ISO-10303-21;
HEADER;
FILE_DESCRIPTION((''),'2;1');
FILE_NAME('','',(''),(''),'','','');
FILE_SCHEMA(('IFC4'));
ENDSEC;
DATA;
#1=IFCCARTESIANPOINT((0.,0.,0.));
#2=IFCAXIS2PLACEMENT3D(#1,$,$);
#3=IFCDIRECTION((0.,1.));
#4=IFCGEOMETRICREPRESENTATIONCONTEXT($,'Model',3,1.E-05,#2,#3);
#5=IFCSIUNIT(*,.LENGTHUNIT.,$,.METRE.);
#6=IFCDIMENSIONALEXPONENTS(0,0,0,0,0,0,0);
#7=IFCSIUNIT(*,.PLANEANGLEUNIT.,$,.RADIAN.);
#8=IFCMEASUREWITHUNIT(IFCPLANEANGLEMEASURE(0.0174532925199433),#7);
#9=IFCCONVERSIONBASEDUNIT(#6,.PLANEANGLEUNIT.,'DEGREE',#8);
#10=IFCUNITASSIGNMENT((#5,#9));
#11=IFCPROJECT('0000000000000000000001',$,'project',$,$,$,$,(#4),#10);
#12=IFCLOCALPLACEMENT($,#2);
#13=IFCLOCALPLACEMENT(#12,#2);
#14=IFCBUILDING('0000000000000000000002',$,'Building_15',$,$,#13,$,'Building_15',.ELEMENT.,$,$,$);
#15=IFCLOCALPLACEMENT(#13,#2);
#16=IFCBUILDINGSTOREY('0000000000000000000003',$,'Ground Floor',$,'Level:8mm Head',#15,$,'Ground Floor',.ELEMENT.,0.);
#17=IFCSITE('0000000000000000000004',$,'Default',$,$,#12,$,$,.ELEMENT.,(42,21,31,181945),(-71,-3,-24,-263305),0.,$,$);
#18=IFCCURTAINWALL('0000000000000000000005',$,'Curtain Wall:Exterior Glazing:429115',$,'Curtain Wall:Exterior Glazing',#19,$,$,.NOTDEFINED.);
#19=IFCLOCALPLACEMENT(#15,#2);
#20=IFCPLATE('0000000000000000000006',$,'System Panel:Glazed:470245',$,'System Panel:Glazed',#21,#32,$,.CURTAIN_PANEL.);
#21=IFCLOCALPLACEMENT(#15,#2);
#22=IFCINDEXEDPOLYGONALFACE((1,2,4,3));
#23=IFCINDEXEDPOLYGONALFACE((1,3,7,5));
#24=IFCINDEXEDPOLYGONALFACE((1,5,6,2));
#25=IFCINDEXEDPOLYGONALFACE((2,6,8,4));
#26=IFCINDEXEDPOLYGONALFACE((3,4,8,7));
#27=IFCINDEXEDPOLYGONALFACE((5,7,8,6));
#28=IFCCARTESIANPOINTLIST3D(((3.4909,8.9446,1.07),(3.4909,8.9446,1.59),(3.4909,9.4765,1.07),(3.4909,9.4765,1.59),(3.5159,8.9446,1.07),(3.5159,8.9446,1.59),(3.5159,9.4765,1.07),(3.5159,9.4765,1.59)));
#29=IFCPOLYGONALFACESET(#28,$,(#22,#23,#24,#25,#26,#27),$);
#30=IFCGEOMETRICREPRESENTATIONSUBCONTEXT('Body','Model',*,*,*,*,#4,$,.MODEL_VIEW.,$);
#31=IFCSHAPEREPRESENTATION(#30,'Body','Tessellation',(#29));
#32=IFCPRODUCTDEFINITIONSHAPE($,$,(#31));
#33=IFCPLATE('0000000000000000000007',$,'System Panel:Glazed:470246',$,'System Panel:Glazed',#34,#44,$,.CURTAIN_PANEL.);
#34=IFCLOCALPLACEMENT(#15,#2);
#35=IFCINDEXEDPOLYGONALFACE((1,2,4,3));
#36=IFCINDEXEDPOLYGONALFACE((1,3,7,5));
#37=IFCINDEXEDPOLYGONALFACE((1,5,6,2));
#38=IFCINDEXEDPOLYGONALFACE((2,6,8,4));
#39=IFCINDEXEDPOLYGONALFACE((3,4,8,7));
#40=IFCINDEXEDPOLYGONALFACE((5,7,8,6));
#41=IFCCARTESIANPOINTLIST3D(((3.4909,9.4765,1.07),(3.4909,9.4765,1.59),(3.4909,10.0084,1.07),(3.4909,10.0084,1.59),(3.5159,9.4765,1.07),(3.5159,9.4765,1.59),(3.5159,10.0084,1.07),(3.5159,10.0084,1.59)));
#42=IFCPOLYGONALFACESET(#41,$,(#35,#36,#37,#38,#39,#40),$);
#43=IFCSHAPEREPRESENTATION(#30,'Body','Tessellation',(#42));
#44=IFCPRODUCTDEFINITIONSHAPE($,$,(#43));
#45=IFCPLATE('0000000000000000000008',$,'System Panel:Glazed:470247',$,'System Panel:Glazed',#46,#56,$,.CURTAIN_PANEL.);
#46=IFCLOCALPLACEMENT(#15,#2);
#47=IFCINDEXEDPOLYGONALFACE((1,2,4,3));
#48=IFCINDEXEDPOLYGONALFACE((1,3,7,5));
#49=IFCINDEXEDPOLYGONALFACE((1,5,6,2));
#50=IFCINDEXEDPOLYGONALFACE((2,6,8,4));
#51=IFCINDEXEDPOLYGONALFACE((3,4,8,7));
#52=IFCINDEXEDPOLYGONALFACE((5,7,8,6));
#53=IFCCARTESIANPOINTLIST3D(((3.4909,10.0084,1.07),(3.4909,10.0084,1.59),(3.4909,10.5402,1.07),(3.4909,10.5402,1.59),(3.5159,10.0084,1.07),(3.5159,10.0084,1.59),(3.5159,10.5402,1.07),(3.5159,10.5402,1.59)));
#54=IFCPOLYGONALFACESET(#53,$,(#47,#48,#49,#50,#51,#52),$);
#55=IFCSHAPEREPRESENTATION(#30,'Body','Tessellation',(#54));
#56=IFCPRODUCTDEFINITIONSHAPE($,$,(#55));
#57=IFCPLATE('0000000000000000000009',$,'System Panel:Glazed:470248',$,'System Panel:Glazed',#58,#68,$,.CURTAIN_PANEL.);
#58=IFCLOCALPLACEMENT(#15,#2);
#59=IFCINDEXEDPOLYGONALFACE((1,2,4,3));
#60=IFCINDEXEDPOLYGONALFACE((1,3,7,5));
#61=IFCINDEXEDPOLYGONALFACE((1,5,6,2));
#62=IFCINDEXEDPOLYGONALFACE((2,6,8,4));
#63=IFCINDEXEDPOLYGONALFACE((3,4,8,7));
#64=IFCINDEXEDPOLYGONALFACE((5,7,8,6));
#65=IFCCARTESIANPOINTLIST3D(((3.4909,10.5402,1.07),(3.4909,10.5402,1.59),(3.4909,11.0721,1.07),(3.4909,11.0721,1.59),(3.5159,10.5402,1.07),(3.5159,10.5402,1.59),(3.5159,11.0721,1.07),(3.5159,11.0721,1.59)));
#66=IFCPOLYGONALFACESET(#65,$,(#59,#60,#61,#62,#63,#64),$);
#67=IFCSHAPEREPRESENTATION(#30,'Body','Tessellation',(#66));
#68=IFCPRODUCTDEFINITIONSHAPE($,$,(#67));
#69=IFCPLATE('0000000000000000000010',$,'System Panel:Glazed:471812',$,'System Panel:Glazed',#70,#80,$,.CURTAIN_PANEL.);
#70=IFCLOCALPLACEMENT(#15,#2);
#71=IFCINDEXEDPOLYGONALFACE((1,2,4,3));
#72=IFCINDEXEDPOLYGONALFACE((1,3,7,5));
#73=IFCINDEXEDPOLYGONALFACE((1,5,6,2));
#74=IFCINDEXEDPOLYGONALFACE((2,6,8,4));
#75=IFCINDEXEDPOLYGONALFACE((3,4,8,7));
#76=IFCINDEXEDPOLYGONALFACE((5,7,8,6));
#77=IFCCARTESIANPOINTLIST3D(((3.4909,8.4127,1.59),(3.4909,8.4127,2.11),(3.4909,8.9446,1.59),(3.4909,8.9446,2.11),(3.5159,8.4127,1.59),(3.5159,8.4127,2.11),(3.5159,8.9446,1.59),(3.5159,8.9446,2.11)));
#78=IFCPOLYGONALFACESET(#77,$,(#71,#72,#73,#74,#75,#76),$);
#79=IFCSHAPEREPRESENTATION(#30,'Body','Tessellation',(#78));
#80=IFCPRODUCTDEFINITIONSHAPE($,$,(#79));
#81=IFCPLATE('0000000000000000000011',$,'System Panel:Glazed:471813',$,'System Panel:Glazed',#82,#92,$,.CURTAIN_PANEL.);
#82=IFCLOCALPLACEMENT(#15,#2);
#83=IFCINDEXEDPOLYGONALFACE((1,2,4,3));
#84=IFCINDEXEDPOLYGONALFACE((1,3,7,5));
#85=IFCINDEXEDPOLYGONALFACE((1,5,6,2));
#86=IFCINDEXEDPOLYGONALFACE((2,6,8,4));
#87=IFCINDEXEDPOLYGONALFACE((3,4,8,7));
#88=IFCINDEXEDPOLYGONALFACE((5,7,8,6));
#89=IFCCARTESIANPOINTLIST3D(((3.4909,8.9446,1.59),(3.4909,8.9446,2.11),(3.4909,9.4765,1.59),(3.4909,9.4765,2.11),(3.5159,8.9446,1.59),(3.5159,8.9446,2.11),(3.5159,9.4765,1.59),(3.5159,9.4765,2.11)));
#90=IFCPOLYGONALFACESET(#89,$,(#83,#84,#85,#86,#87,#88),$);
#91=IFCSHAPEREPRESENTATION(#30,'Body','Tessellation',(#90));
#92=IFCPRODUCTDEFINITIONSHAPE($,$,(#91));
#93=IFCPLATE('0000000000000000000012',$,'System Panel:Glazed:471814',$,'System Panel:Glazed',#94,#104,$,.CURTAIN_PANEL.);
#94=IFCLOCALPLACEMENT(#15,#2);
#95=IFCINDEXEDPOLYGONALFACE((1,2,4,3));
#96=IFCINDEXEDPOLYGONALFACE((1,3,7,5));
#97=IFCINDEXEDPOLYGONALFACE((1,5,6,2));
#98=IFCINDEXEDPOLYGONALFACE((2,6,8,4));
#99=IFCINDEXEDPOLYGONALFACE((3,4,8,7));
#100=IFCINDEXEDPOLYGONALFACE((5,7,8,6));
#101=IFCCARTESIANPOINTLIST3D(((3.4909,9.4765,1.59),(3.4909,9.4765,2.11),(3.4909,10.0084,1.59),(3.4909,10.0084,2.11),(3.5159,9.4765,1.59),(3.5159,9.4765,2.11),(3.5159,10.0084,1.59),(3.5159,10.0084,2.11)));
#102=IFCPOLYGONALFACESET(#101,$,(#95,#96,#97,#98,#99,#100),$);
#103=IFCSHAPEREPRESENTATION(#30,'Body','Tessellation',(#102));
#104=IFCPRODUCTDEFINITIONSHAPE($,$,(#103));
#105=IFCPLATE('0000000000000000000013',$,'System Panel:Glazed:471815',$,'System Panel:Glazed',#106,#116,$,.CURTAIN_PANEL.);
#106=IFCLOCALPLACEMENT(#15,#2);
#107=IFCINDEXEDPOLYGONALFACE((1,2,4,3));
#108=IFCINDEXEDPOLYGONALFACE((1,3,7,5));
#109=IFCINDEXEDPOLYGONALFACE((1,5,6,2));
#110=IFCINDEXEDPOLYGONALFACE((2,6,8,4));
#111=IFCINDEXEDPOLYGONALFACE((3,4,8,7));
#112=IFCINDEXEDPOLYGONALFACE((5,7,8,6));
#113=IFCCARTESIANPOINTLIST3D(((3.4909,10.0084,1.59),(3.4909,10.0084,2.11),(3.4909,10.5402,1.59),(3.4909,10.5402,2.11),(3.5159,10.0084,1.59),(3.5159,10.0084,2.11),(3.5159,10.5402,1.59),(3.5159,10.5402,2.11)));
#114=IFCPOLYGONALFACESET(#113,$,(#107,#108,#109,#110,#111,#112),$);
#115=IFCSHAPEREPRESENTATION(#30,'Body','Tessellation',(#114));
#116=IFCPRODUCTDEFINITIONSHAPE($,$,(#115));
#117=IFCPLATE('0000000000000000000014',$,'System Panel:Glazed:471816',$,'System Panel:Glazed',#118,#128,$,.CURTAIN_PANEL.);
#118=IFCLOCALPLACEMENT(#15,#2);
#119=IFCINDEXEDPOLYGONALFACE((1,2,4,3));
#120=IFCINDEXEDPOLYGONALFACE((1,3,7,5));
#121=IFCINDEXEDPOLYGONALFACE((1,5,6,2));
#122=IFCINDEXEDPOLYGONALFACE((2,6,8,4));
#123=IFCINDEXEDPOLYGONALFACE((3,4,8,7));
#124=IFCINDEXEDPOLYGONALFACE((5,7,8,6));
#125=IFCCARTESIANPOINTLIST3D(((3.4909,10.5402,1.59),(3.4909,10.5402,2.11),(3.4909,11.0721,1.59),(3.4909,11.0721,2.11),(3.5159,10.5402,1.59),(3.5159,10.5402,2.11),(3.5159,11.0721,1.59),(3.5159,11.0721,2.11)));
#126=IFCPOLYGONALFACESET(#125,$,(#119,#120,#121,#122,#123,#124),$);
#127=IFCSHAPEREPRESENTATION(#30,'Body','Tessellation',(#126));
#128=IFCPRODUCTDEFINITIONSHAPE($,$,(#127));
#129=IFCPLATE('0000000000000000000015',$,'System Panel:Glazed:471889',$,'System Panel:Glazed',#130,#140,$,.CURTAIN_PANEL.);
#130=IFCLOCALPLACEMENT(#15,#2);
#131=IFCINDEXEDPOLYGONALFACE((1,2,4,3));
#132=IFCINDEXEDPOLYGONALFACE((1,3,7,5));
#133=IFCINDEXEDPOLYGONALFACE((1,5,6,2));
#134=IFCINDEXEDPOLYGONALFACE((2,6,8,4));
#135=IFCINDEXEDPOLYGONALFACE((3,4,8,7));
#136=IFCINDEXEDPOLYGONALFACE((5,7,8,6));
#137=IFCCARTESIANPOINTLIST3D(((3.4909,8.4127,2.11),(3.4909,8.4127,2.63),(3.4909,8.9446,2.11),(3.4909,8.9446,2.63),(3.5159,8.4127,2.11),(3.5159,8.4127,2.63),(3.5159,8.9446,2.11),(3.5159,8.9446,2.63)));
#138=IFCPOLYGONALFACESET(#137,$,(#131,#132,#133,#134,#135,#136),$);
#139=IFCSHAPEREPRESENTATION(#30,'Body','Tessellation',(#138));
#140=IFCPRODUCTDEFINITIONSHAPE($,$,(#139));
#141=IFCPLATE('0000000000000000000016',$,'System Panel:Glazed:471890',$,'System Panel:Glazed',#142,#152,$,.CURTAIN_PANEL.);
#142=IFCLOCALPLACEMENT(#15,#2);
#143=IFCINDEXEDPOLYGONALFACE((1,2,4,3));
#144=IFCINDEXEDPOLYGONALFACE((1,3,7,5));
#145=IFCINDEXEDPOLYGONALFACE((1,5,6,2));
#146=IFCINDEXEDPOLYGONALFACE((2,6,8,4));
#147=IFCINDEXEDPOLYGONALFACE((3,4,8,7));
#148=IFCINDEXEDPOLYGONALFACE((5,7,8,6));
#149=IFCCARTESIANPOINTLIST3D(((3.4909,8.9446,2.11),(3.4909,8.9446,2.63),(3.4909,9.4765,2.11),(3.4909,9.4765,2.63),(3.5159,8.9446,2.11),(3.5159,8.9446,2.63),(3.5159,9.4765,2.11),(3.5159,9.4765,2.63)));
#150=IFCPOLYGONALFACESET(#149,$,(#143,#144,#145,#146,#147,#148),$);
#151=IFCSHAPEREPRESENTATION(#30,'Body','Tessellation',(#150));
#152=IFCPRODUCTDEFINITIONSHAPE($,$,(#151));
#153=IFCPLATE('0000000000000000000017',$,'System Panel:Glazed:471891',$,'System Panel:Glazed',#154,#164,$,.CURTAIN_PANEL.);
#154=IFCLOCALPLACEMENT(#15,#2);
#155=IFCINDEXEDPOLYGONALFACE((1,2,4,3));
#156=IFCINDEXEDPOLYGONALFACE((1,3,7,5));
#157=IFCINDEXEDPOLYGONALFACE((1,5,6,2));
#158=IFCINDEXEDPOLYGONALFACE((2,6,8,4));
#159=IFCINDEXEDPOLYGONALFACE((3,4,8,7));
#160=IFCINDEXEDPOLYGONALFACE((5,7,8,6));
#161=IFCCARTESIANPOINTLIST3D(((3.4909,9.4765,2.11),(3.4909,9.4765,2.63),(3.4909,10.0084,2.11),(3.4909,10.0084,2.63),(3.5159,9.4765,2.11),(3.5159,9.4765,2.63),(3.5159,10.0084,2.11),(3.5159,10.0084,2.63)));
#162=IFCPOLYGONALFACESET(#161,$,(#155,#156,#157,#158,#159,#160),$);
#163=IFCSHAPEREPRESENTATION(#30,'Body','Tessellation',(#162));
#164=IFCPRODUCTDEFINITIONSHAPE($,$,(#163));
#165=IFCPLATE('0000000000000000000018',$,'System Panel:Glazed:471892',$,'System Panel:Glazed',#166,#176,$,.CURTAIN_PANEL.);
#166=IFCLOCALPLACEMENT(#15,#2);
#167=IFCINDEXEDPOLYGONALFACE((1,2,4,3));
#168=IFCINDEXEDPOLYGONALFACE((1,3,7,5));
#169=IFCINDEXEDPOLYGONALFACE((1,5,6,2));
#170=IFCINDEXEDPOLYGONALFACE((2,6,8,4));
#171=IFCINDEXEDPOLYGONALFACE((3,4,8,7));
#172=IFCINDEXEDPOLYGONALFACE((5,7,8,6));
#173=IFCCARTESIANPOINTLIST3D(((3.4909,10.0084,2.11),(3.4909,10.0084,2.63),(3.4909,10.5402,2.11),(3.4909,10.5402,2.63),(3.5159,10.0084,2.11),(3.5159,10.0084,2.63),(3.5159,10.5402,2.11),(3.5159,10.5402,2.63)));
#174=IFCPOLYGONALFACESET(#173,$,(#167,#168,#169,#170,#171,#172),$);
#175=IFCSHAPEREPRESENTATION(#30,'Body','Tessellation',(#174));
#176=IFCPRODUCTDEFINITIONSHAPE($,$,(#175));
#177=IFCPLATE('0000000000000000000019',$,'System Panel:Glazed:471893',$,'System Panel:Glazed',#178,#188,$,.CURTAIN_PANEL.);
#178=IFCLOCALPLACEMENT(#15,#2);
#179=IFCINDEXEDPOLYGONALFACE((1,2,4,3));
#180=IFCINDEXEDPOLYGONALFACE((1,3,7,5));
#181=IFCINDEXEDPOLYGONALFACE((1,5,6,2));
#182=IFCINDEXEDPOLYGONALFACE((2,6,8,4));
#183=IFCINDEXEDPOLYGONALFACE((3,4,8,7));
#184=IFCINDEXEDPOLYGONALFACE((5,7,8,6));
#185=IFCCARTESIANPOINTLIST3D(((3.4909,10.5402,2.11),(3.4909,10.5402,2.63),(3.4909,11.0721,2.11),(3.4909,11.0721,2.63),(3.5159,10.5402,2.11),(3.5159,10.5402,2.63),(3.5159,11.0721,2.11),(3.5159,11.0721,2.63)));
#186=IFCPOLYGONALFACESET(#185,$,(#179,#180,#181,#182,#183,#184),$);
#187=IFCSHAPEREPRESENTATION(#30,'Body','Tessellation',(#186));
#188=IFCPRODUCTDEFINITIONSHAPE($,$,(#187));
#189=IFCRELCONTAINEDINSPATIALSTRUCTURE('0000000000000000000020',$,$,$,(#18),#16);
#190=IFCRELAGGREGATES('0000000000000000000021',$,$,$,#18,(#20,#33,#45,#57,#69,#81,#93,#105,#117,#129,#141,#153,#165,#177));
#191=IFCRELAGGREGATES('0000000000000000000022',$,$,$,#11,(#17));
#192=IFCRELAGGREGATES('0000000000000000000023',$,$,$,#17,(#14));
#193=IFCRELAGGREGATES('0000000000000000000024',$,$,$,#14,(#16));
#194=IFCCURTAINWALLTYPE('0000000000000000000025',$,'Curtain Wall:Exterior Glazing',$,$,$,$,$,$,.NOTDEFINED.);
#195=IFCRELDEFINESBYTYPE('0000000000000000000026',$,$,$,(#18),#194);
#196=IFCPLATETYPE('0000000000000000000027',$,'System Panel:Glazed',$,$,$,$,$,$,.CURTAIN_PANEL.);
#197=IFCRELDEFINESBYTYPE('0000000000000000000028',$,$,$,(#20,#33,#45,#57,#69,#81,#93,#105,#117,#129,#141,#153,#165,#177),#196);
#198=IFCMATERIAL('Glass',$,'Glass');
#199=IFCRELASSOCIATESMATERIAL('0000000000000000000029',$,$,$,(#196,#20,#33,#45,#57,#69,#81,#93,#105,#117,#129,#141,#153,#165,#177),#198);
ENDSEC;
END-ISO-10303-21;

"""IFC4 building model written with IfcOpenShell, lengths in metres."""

from ifc_helpers import new_model, entity, si_unit, converted_unit, direction, frame, origin, place, context, subcontext, project, spatial, indexed_curve, outline, extrude, source, transform, mapped, material, type_object, type_shapes, element, aggregate, save


model = new_model("IFC4")

# Units and contexts
model_context = context("Model", 3, precision=1e-05, world=origin(), true_north=direction((0.0, 1.0)))
body_context = subcontext(model_context, "Body", "Model", "MODEL_VIEW")
ifc_project = project(units=[si_unit("LENGTHUNIT", "METRE"), converted_unit("PLANEANGLEUNIT", "DEGREE", entity("IfcPlaneAngleMeasure", 0.0174532925199433), si_unit("PLANEANGLEUNIT", "RADIAN"), dimensions=[0, 0, 0, 0, 0, 0, 0])], contexts=[model_context])

# Site, building, storey
site_placement = place(None, origin())
site = spatial("IfcSite", under=ifc_project, at=site_placement, Name="Default", CompositionType="ELEMENT", RefLatitude=(42, 21, 31, 181945), RefLongitude=(-71, -3, -24, -263305), RefElevation=0.0)
building_placement = place(site_placement, origin())
building = spatial("IfcBuilding", under=site, at=building_placement, Name="Building_15", LongName="Building_15", CompositionType="ELEMENT")
storey_placement = place(building_placement, origin())
storey = spatial("IfcBuildingStorey", under=building, at=storey_placement, Name="Ground Floor", ObjectType="Level:8mm Head", LongName="Ground Floor", CompositionType="ELEMENT", Elevation=0.0)

# Curtain wall, plates
curtain_wall_type = type_object("IfcCurtainWallType", Name="Curtain Wall:Exterior Glazing", PredefinedType="NOTDEFINED")
curtain_wall_placement = place(storey_placement, origin())
curtain_wall = element("IfcCurtainWall", 1, at=curtain_wall_placement, inside=storey, type_object=curtain_wall_type, Name="Curtain Wall:Exterior Glazing:429115", ObjectType="Curtain Wall:Exterior Glazing", PredefinedType="NOTDEFINED")
ifc_material_1 = material(Name="Glass", Category="Glass")
plate_type_1 = type_object("IfcPlateType", Name="System Panel:Glazed", PredefinedType="CURTAIN_PANEL", material=ifc_material_1)
shared_shape_1 = source(origin(), body_context, "Body", "SweptSolid", [
    extrude(outline(indexed_curve([(-0.0125, -0.2659), (0.0125, -0.2659), (0.0125, 0.2659), (-0.0125, 0.2659), (-0.0125, -0.2659)], self_intersect=False)), frame((0.0, 0.037, 0.0), z_axis=(0.0, 0.0, 1.0), x_axis=(0.0, 1.0, 0.0)), (0.0, 0.0, 1.0), 0.52),
])
type_shapes(plate_type_1, [shared_shape_1])
plate_1_placement = place(curtain_wall_placement, frame((3.5404, 9.2106, 1.07), z_axis=(0.0, 0.0, 1.0), x_axis=(0.0, 1.0, 0.0)))
plate_1 = element("IfcPlate", 2, at=plate_1_placement, type_object=plate_type_1, material=ifc_material_1, Name="System Panel:Glazed:470245", ObjectType="System Panel:Glazed", PredefinedType="CURTAIN_PANEL", context=body_context, shape_type="MappedRepresentation", body=[
    mapped(shared_shape_1, transform((0.0, 0.0, 0.0), scale=1.0)),
])
plate_2_placement = place(curtain_wall_placement, frame((3.5404, 9.7424, 1.07), z_axis=(0.0, 0.0, 1.0), x_axis=(0.0, 1.0, 0.0)))
plate_2 = element("IfcPlate", 3, at=plate_2_placement, type_object=plate_type_1, material=ifc_material_1, Name="System Panel:Glazed:470246", ObjectType="System Panel:Glazed", PredefinedType="CURTAIN_PANEL", context=body_context, shape_type="MappedRepresentation", body=[
    mapped(shared_shape_1, transform((0.0, 0.0, 0.0), scale=1.0)),
])
plate_3_placement = place(curtain_wall_placement, frame((3.5404, 10.2743, 1.07), z_axis=(0.0, 0.0, 1.0), x_axis=(0.0, 1.0, 0.0)))
plate_3 = element("IfcPlate", 4, at=plate_3_placement, type_object=plate_type_1, material=ifc_material_1, Name="System Panel:Glazed:470247", ObjectType="System Panel:Glazed", PredefinedType="CURTAIN_PANEL", context=body_context, shape_type="MappedRepresentation", body=[
    mapped(shared_shape_1, transform((0.0, 0.0, 0.0), scale=1.0)),
])
plate_4_placement = place(curtain_wall_placement, frame((3.5404, 10.8062, 1.07), z_axis=(0.0, 0.0, 1.0), x_axis=(0.0, 1.0, 0.0)))
plate_4 = element("IfcPlate", 5, at=plate_4_placement, type_object=plate_type_1, material=ifc_material_1, Name="System Panel:Glazed:470248", ObjectType="System Panel:Glazed", PredefinedType="CURTAIN_PANEL", context=body_context, shape_type="MappedRepresentation", body=[
    mapped(shared_shape_1, transform((0.0, 0.0, 0.0), scale=1.0)),
])
plate_5_placement = place(curtain_wall_placement, frame((3.5404, 8.6787, 1.59), z_axis=(0.0, 0.0, 1.0), x_axis=(0.0, 1.0, 0.0)))
plate_5 = element("IfcPlate", 6, at=plate_5_placement, type_object=plate_type_1, material=ifc_material_1, Name="System Panel:Glazed:471812", ObjectType="System Panel:Glazed", PredefinedType="CURTAIN_PANEL", context=body_context, shape_type="MappedRepresentation", body=[
    mapped(shared_shape_1, transform((0.0, 0.0, 0.0), scale=1.0)),
])
plate_6_placement = place(curtain_wall_placement, frame((3.5404, 9.2106, 1.59), z_axis=(0.0, 0.0, 1.0), x_axis=(0.0, 1.0, 0.0)))
plate_6 = element("IfcPlate", 7, at=plate_6_placement, type_object=plate_type_1, material=ifc_material_1, Name="System Panel:Glazed:471813", ObjectType="System Panel:Glazed", PredefinedType="CURTAIN_PANEL", context=body_context, shape_type="MappedRepresentation", body=[
    mapped(shared_shape_1, transform((0.0, 0.0, 0.0), scale=1.0)),
])
plate_7_placement = place(curtain_wall_placement, frame((3.5404, 9.7424, 1.59), z_axis=(0.0, 0.0, 1.0), x_axis=(0.0, 1.0, 0.0)))
plate_7 = element("IfcPlate", 8, at=plate_7_placement, type_object=plate_type_1, material=ifc_material_1, Name="System Panel:Glazed:471814", ObjectType="System Panel:Glazed", PredefinedType="CURTAIN_PANEL", context=body_context, shape_type="MappedRepresentation", body=[
    mapped(shared_shape_1, transform((0.0, 0.0, 0.0), scale=1.0)),
])
plate_8_placement = place(curtain_wall_placement, frame((3.5404, 10.2743, 1.59), z_axis=(0.0, 0.0, 1.0), x_axis=(0.0, 1.0, 0.0)))
plate_8 = element("IfcPlate", 9, at=plate_8_placement, type_object=plate_type_1, material=ifc_material_1, Name="System Panel:Glazed:471815", ObjectType="System Panel:Glazed", PredefinedType="CURTAIN_PANEL", context=body_context, shape_type="MappedRepresentation", body=[
    mapped(shared_shape_1, transform((0.0, 0.0, 0.0), scale=1.0)),
])
plate_9_placement = place(curtain_wall_placement, frame((3.5404, 10.8062, 1.59), z_axis=(0.0, 0.0, 1.0), x_axis=(0.0, 1.0, 0.0)))
plate_9 = element("IfcPlate", 10, at=plate_9_placement, type_object=plate_type_1, material=ifc_material_1, Name="System Panel:Glazed:471816", ObjectType="System Panel:Glazed", PredefinedType="CURTAIN_PANEL", context=body_context, shape_type="MappedRepresentation", body=[
    mapped(shared_shape_1, transform((0.0, 0.0, 0.0), scale=1.0)),
])
plate_10_placement = place(curtain_wall_placement, frame((3.5404, 8.6787, 2.11), z_axis=(0.0, 0.0, 1.0), x_axis=(0.0, 1.0, 0.0)))
plate_10 = element("IfcPlate", 11, at=plate_10_placement, type_object=plate_type_1, material=ifc_material_1, Name="System Panel:Glazed:471889", ObjectType="System Panel:Glazed", PredefinedType="CURTAIN_PANEL", context=body_context, shape_type="MappedRepresentation", body=[
    mapped(shared_shape_1, transform((0.0, 0.0, 0.0), scale=1.0)),
])
plate_11_placement = place(curtain_wall_placement, frame((3.5404, 9.2106, 2.11), z_axis=(0.0, 0.0, 1.0), x_axis=(0.0, 1.0, 0.0)))
plate_11 = element("IfcPlate", 12, at=plate_11_placement, type_object=plate_type_1, material=ifc_material_1, Name="System Panel:Glazed:471890", ObjectType="System Panel:Glazed", PredefinedType="CURTAIN_PANEL", context=body_context, shape_type="MappedRepresentation", body=[
    mapped(shared_shape_1, transform((0.0, 0.0, 0.0), scale=1.0)),
])
plate_12_placement = place(curtain_wall_placement, frame((3.5404, 9.7424, 2.11), z_axis=(0.0, 0.0, 1.0), x_axis=(0.0, 1.0, 0.0)))
plate_12 = element("IfcPlate", 13, at=plate_12_placement, type_object=plate_type_1, material=ifc_material_1, Name="System Panel:Glazed:471891", ObjectType="System Panel:Glazed", PredefinedType="CURTAIN_PANEL", context=body_context, shape_type="MappedRepresentation", body=[
    mapped(shared_shape_1, transform((0.0, 0.0, 0.0), scale=1.0)),
])
plate_13_placement = place(curtain_wall_placement, frame((3.5404, 10.2743, 2.11), z_axis=(0.0, 0.0, 1.0), x_axis=(0.0, 1.0, 0.0)))
plate_13 = element("IfcPlate", 14, at=plate_13_placement, type_object=plate_type_1, material=ifc_material_1, Name="System Panel:Glazed:471892", ObjectType="System Panel:Glazed", PredefinedType="CURTAIN_PANEL", context=body_context, shape_type="MappedRepresentation", body=[
    mapped(shared_shape_1, transform((0.0, 0.0, 0.0), scale=1.0)),
])
plate_14_placement = place(curtain_wall_placement, frame((3.5404, 10.8062, 2.11), z_axis=(0.0, 0.0, 1.0), x_axis=(0.0, 1.0, 0.0)))
plate_14 = element("IfcPlate", 15, at=plate_14_placement, type_object=plate_type_1, material=ifc_material_1, Name="System Panel:Glazed:471893", ObjectType="System Panel:Glazed", PredefinedType="CURTAIN_PANEL", context=body_context, shape_type="MappedRepresentation", body=[
    mapped(shared_shape_1, transform((0.0, 0.0, 0.0), scale=1.0)),
])
aggregate(curtain_wall, [plate_1, plate_2, plate_3, plate_4, plate_5, plate_6, plate_7, plate_8, plate_9, plate_10, plate_11, plate_12, plate_13, plate_14])

save(model, "model.ifc")
